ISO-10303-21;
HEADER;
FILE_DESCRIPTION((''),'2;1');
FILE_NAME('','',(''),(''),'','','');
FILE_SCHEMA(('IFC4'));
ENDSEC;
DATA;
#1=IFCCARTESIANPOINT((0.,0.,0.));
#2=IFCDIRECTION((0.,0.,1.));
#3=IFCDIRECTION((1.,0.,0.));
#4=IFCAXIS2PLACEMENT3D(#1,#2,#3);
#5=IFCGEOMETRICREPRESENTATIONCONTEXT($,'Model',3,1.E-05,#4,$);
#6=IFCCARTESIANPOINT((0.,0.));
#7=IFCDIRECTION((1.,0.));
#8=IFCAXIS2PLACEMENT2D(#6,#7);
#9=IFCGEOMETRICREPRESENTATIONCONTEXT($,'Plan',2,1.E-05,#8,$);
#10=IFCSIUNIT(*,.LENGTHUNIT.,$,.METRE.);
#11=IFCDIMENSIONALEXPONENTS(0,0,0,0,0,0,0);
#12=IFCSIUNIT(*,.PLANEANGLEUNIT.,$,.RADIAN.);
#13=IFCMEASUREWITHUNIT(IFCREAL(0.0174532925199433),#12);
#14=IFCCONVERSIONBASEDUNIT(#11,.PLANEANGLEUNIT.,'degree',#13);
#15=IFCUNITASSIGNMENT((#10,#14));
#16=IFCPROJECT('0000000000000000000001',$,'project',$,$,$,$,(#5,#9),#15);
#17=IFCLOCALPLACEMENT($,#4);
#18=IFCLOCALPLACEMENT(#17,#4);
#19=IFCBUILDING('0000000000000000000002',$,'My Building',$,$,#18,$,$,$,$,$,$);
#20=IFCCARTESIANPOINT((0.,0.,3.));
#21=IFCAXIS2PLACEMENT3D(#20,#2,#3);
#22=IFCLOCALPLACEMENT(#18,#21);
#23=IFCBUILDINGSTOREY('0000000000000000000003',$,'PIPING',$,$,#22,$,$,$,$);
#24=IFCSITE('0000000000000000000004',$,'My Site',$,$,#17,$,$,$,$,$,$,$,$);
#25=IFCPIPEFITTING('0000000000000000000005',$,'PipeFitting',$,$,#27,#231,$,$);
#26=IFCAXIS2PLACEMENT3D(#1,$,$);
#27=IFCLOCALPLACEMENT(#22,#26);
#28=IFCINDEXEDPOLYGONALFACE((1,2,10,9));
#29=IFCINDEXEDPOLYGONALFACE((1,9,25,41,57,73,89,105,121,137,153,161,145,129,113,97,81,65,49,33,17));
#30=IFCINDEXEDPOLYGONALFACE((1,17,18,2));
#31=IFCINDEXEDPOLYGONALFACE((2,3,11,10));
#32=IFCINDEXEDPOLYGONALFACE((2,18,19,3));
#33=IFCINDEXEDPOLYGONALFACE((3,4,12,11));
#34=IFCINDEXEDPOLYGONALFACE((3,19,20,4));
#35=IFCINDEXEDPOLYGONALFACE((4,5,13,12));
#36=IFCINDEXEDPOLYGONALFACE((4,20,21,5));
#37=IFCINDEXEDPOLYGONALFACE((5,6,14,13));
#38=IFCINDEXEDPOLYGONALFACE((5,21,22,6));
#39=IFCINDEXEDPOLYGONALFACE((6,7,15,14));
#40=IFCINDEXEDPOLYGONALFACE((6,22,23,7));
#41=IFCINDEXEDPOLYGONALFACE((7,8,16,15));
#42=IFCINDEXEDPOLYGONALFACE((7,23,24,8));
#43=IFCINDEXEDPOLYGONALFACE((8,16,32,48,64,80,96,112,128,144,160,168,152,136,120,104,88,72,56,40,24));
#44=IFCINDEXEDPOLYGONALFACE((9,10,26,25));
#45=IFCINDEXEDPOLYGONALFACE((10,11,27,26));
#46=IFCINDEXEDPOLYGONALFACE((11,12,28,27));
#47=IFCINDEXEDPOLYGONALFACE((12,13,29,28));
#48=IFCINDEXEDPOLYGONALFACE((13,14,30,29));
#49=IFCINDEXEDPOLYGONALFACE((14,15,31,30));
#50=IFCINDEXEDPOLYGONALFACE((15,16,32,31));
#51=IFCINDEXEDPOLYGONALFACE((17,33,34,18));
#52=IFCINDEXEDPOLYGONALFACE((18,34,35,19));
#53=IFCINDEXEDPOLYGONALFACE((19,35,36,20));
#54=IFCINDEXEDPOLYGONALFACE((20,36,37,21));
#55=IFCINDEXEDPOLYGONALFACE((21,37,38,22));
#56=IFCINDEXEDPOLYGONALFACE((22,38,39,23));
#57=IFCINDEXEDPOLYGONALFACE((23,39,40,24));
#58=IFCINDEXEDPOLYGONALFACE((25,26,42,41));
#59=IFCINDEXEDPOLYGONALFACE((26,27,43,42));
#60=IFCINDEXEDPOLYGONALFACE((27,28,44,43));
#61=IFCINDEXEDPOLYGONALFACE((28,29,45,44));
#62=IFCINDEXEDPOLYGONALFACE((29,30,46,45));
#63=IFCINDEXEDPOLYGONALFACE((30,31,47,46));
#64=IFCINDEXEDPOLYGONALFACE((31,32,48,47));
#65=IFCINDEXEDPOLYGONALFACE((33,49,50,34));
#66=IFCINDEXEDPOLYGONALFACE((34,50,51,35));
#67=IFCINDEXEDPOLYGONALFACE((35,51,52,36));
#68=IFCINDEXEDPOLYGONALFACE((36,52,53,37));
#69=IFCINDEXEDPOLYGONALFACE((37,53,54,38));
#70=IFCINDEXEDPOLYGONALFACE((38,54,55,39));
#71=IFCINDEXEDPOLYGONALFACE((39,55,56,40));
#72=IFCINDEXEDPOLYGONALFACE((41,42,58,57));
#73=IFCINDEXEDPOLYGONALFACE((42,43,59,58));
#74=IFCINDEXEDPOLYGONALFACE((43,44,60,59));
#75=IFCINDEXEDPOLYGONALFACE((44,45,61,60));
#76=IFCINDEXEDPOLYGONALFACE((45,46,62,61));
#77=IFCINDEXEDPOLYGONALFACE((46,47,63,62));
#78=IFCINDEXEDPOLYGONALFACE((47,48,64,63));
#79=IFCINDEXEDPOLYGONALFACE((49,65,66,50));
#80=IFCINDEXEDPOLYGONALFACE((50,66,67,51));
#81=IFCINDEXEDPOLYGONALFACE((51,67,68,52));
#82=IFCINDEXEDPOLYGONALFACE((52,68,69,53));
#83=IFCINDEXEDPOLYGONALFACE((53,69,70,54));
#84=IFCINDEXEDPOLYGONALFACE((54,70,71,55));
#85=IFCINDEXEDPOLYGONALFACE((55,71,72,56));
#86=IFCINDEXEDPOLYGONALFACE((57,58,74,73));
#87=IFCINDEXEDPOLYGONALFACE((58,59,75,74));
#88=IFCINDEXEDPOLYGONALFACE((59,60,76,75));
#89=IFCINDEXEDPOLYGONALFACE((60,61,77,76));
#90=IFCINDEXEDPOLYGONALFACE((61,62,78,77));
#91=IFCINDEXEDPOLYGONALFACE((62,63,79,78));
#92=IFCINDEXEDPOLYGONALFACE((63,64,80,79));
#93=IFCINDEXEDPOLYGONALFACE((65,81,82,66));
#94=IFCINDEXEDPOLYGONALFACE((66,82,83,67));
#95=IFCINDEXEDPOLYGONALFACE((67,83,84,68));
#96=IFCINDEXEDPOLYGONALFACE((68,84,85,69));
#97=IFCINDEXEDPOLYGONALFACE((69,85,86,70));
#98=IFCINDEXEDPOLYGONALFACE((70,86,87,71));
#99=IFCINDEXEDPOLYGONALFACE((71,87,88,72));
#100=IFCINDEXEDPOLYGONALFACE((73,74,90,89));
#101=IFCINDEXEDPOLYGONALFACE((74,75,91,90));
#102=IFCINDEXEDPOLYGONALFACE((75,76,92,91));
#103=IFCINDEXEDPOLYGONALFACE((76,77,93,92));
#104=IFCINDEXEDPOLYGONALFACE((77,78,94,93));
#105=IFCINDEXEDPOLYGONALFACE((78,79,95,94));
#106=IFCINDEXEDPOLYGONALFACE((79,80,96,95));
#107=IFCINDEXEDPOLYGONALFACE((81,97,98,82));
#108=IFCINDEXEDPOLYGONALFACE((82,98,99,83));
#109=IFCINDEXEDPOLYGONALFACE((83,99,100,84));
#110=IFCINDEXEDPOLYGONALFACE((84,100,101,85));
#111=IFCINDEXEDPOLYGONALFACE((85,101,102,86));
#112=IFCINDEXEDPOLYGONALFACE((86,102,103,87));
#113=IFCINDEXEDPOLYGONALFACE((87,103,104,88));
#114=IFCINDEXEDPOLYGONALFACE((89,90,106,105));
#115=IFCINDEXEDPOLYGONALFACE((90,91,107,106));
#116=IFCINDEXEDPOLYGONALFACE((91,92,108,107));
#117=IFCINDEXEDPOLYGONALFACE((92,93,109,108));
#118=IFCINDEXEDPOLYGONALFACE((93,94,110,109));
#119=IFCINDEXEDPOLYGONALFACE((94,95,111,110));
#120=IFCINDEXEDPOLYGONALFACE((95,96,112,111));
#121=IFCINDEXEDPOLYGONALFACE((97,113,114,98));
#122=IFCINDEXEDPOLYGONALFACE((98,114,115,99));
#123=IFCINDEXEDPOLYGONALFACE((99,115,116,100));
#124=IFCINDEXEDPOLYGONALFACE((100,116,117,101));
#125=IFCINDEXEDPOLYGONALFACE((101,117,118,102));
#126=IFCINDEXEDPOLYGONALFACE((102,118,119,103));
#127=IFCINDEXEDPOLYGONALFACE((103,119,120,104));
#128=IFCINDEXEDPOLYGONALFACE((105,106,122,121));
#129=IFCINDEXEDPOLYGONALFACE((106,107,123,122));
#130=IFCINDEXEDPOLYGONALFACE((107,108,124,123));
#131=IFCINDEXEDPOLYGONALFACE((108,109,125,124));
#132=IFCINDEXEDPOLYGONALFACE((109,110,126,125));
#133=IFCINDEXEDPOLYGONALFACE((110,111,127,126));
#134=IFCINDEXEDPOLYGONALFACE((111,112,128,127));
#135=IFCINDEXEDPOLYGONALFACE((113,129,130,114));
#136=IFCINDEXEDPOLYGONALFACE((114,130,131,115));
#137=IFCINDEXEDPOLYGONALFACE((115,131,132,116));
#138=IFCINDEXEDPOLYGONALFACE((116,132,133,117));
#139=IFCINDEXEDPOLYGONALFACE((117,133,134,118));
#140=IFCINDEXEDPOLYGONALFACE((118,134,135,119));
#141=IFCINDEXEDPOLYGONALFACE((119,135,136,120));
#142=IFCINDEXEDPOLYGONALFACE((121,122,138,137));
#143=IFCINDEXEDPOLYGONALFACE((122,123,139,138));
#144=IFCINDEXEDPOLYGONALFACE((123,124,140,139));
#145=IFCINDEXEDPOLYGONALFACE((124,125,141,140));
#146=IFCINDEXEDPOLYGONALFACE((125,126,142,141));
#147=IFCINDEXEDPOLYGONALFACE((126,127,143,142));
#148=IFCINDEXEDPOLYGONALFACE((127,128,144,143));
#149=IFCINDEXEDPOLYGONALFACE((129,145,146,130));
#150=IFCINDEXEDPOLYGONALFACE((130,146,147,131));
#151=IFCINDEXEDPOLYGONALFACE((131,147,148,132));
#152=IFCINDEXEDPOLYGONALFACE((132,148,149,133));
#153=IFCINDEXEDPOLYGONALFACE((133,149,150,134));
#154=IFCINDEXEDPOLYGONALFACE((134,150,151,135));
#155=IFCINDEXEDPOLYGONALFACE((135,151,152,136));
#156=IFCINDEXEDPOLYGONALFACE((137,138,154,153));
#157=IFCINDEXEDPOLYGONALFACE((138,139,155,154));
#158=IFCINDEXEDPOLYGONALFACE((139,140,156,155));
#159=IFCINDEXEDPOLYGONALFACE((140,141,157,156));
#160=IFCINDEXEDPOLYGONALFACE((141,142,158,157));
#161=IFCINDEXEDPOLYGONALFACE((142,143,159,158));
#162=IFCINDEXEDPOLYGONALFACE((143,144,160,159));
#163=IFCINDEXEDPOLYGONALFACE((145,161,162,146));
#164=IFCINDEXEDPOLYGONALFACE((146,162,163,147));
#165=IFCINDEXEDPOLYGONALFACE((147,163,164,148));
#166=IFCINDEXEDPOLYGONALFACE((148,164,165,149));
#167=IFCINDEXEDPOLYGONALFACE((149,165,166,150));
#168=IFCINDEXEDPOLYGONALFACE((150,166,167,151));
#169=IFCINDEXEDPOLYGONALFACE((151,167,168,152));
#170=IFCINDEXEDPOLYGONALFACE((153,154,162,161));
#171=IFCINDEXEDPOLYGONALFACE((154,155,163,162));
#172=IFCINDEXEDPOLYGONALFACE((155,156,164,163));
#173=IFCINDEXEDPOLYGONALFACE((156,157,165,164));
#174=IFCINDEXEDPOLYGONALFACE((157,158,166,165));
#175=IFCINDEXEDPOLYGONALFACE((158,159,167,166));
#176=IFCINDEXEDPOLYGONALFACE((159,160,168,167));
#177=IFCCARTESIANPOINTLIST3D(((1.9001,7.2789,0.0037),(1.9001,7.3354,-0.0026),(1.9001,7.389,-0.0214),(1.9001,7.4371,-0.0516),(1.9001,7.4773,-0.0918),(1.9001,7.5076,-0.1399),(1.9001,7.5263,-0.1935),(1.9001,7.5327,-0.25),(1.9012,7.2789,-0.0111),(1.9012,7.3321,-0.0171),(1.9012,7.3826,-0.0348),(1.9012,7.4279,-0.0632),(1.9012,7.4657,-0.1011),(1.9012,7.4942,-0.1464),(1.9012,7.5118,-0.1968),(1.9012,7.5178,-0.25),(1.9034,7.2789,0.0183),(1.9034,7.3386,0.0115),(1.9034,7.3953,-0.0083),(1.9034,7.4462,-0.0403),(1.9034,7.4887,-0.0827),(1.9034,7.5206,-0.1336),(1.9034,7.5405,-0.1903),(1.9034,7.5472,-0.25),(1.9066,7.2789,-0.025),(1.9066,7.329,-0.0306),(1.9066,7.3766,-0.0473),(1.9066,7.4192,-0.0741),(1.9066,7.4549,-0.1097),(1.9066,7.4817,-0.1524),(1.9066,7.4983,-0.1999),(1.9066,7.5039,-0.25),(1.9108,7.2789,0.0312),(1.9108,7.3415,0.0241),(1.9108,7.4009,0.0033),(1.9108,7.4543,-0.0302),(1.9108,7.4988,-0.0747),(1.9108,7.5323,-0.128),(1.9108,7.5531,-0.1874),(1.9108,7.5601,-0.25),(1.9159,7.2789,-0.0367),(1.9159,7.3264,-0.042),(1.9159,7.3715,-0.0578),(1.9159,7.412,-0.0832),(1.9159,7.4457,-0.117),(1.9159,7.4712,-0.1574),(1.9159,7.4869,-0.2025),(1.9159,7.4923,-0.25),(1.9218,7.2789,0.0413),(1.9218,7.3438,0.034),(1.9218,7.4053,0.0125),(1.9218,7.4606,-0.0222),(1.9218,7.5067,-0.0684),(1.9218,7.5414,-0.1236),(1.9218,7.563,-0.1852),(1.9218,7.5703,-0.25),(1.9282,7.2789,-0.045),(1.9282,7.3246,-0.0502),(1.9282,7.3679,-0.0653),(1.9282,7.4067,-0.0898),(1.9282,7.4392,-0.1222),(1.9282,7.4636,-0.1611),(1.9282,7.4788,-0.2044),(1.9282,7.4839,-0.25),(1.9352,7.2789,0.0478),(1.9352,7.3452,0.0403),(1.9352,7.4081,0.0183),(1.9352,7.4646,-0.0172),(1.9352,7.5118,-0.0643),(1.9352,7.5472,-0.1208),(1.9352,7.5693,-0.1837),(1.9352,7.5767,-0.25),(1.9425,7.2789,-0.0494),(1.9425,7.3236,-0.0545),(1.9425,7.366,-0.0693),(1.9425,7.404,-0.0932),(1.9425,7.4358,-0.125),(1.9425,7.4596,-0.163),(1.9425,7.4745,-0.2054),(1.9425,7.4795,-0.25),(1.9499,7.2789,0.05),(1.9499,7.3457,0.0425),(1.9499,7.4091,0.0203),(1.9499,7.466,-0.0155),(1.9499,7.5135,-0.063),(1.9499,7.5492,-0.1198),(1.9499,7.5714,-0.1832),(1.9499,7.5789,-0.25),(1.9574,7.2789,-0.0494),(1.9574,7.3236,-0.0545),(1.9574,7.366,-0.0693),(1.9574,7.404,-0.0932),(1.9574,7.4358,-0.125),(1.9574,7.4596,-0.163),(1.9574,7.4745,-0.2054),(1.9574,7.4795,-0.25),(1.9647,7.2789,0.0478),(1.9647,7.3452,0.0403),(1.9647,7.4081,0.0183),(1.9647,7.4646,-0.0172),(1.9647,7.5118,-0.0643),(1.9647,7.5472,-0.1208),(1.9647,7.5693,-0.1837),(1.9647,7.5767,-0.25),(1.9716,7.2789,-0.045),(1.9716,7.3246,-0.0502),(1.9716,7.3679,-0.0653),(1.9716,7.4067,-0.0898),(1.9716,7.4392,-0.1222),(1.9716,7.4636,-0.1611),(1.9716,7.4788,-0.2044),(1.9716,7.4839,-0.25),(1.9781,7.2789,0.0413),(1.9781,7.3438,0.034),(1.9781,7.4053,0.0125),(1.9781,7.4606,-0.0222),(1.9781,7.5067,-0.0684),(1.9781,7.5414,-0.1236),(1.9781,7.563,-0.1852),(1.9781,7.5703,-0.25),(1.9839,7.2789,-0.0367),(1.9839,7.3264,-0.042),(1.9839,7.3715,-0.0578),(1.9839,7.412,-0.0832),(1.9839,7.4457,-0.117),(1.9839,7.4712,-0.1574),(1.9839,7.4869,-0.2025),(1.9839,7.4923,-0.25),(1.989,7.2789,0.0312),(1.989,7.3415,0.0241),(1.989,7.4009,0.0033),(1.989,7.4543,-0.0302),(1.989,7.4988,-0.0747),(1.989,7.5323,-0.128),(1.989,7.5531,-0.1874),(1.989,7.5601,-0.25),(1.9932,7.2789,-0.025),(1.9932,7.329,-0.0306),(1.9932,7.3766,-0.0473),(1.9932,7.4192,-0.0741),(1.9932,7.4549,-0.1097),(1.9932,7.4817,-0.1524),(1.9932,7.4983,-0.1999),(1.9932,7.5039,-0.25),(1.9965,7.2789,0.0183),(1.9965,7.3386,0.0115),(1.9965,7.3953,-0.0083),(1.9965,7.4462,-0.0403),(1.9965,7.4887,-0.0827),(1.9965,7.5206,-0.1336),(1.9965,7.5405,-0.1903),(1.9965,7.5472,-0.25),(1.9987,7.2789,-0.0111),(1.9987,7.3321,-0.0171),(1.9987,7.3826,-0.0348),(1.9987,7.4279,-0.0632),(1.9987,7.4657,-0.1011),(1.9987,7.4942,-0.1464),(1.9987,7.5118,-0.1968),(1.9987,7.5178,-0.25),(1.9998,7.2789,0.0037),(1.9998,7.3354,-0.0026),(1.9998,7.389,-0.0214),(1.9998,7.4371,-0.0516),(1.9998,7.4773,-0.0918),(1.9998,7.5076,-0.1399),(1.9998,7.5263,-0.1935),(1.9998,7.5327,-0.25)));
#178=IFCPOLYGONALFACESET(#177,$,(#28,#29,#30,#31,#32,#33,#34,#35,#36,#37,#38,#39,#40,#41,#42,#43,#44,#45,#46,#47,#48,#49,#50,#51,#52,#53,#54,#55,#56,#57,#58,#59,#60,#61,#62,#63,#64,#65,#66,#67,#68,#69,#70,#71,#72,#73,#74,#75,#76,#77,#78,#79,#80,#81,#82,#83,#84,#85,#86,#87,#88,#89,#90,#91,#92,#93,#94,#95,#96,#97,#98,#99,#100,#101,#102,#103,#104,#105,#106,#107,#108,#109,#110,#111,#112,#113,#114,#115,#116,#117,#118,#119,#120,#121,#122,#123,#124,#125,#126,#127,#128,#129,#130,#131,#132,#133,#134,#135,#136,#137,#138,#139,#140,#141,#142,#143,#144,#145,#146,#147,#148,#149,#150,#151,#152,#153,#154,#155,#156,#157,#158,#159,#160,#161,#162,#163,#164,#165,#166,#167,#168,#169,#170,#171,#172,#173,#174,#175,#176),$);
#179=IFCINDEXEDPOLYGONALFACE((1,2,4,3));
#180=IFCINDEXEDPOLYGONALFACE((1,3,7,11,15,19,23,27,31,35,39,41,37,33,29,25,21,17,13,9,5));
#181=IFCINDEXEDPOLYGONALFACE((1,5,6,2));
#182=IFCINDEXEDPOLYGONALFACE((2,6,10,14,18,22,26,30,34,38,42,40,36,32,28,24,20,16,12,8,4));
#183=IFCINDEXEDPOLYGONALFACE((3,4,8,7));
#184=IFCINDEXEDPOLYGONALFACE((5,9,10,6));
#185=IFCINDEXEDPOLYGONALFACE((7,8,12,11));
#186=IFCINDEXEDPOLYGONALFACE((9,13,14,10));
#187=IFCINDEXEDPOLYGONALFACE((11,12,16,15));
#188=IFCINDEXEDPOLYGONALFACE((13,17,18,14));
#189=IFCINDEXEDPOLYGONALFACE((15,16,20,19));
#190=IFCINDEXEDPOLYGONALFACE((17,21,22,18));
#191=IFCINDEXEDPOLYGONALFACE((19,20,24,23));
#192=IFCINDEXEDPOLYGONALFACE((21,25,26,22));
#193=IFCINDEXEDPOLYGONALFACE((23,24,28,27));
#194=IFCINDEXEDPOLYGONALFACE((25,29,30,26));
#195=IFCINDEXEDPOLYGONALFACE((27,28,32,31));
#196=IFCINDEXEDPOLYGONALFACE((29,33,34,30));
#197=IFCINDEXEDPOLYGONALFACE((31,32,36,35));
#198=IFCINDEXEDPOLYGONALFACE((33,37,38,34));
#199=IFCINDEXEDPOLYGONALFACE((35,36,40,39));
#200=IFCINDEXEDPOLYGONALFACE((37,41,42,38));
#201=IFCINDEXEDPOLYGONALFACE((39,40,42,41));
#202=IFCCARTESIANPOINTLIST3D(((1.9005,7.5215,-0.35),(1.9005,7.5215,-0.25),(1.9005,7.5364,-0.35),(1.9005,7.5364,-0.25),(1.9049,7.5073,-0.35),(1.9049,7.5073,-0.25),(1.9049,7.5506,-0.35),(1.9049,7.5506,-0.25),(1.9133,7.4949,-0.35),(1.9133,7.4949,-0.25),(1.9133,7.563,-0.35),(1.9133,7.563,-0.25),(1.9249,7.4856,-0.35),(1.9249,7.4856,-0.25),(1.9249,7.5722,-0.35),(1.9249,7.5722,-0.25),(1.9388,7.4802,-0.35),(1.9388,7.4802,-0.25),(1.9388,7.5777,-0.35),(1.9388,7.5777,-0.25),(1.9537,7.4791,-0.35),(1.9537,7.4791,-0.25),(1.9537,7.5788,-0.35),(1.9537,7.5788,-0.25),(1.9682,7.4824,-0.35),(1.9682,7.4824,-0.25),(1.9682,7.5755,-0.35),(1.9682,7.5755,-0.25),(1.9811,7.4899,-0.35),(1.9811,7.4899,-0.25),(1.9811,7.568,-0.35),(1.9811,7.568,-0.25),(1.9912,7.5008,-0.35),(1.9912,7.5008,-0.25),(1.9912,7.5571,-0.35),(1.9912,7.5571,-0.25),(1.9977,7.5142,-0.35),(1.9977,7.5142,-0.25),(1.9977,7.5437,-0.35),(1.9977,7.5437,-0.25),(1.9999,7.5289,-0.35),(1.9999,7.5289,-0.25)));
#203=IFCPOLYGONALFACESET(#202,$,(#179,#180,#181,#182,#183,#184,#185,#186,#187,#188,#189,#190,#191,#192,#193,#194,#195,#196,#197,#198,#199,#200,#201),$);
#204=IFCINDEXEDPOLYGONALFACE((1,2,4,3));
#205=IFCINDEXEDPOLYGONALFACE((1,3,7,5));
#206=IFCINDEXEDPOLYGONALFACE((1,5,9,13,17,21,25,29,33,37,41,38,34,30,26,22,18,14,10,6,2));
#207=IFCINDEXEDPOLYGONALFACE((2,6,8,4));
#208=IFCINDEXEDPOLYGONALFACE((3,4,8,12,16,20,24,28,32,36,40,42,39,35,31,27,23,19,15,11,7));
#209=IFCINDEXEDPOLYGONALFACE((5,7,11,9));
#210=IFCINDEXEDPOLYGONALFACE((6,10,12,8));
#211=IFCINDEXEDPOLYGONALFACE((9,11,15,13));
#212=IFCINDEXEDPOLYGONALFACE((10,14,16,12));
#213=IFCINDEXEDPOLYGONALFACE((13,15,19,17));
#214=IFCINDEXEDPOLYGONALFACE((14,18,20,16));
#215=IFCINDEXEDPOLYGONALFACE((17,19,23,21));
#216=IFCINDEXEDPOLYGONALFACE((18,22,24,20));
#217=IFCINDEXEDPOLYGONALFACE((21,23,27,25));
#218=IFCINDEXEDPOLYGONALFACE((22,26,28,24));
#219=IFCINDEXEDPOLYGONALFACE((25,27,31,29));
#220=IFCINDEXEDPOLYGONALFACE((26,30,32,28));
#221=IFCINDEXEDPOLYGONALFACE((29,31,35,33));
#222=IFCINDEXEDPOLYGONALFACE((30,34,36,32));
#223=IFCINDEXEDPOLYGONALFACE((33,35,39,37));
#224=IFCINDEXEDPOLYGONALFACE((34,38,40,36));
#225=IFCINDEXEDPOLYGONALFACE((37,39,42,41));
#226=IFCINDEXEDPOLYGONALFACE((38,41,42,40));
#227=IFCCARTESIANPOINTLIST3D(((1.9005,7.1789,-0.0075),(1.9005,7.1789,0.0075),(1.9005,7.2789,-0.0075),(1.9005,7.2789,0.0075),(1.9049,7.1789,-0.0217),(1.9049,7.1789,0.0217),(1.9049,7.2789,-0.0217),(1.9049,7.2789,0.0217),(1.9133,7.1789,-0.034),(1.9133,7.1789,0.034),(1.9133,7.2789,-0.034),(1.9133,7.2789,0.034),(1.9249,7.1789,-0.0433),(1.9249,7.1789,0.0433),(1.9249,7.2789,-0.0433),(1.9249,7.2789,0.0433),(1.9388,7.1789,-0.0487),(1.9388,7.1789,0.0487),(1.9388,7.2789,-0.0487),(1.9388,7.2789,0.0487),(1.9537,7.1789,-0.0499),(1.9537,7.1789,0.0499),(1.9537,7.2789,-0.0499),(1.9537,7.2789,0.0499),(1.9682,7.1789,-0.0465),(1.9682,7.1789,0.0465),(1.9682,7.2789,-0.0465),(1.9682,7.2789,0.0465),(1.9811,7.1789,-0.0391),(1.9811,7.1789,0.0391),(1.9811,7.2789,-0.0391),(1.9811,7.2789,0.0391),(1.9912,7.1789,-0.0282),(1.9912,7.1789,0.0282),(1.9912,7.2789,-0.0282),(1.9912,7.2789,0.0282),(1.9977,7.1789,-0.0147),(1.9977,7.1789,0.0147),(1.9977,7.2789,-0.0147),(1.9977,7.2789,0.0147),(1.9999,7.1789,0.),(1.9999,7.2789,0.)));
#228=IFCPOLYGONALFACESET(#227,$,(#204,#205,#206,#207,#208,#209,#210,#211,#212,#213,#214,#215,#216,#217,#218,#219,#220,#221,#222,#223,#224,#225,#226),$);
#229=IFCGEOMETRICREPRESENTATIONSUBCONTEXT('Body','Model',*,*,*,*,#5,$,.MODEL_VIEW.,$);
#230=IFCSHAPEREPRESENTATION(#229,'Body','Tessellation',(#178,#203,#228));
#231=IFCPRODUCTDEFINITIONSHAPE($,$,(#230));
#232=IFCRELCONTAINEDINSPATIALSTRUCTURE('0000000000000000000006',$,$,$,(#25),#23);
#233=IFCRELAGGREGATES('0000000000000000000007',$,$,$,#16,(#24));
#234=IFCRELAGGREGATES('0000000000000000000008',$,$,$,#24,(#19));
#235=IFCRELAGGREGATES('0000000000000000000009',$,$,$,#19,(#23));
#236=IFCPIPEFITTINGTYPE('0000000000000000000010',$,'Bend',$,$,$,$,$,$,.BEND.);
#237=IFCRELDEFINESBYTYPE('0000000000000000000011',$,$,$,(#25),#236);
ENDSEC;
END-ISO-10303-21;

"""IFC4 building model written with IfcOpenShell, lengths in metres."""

from ifc_helpers import new_model, entity, si_unit, converted_unit, frame, origin_with_axes, origin_2d_with_axis, place, context, subcontext, project, spatial, circle, extrude, source, transform, mapped, type_object, type_shapes, element, save


model = new_model("IFC4")

# Units and contexts
model_context = context("Model", 3, precision=1e-05, world=origin_with_axes())
plan_context = context("Plan", 2, precision=1e-05, world=origin_2d_with_axis())
body_context = subcontext(model_context, "Body", "Model", "MODEL_VIEW")
ifc_project = project(units=[si_unit("LENGTHUNIT", "METRE"), converted_unit("PLANEANGLEUNIT", "degree", entity("IfcReal", 0.0174532925199433), si_unit("PLANEANGLEUNIT", "RADIAN"), dimensions=[0, 0, 0, 0, 0, 0, 0])], contexts=[model_context, plan_context])

# Site, building, storey
site_placement = place(None, origin_with_axes())
site = spatial("IfcSite", under=ifc_project, at=site_placement, Name="My Site")
building_placement = place(site_placement, origin_with_axes())
building = spatial("IfcBuilding", under=site, at=building_placement, Name="My Building")
storey_placement = place(building_placement, frame((0.0, 0.0, 3.0), z_axis=(0.0, 0.0, 1.0), x_axis=(1.0, 0.0, 0.0)))
storey = spatial("IfcBuildingStorey", under=building, at=storey_placement, Name="PIPING")

# Pipe fitting
pipe_fitting_type_1 = type_object("IfcPipeFittingType", Name="Bend", PredefinedType="BEND")
shared_shape = source(origin_with_axes(), body_context, "Body", "SolidModel", [
    entity("IfcSweptDiskSolid", entity("IfcIndexedPolyCurve", entity("IfcCartesianPointList3D", [[0.0, 0.0, -0.1], [0.0, 0.0732, -0.2768], [0.0, 0.25, -0.35]]), [entity("IfcArcIndex", [1, 2, 3])]), 0.05),
    extrude(circle(Radius=0.05), origin_with_axes(), (0.0, 0.0, -1.0), 0.1),
    extrude(circle(Radius=0.05), frame((0.0, 0.25, -0.35), z_axis=(0.0, 1.0, 0.0), x_axis=(1.0, 0.0, 0.0)), (0.0, 0.0, 1.0), 0.1),
])
type_shapes(pipe_fitting_type_1, [shared_shape])
for number, where, z_axis, x_axis, name in (
    (1, (1.9499, 7.5289, -0.35), (0.0, 0.0, -1.0), (1.0, 0.0, 0.0), "PipeFitting"),
):
    element("IfcPipeFitting", number, at=place(storey_placement, frame(where, z_axis=z_axis, x_axis=x_axis)), inside=storey, type_object=pipe_fitting_type_1, Name=name, context=body_context, shape_type="MappedRepresentation", body=[
        mapped(shared_shape, transform((0.0, 0.0, 0.0), x_axis=(1.0, 0.0, 0.0), y_axis=(0.0, 1.0, 0.0), z_axis=(0.0, 0.0, 1.0), scale=1.0)),
    ])

save(model, "model.ifc")
